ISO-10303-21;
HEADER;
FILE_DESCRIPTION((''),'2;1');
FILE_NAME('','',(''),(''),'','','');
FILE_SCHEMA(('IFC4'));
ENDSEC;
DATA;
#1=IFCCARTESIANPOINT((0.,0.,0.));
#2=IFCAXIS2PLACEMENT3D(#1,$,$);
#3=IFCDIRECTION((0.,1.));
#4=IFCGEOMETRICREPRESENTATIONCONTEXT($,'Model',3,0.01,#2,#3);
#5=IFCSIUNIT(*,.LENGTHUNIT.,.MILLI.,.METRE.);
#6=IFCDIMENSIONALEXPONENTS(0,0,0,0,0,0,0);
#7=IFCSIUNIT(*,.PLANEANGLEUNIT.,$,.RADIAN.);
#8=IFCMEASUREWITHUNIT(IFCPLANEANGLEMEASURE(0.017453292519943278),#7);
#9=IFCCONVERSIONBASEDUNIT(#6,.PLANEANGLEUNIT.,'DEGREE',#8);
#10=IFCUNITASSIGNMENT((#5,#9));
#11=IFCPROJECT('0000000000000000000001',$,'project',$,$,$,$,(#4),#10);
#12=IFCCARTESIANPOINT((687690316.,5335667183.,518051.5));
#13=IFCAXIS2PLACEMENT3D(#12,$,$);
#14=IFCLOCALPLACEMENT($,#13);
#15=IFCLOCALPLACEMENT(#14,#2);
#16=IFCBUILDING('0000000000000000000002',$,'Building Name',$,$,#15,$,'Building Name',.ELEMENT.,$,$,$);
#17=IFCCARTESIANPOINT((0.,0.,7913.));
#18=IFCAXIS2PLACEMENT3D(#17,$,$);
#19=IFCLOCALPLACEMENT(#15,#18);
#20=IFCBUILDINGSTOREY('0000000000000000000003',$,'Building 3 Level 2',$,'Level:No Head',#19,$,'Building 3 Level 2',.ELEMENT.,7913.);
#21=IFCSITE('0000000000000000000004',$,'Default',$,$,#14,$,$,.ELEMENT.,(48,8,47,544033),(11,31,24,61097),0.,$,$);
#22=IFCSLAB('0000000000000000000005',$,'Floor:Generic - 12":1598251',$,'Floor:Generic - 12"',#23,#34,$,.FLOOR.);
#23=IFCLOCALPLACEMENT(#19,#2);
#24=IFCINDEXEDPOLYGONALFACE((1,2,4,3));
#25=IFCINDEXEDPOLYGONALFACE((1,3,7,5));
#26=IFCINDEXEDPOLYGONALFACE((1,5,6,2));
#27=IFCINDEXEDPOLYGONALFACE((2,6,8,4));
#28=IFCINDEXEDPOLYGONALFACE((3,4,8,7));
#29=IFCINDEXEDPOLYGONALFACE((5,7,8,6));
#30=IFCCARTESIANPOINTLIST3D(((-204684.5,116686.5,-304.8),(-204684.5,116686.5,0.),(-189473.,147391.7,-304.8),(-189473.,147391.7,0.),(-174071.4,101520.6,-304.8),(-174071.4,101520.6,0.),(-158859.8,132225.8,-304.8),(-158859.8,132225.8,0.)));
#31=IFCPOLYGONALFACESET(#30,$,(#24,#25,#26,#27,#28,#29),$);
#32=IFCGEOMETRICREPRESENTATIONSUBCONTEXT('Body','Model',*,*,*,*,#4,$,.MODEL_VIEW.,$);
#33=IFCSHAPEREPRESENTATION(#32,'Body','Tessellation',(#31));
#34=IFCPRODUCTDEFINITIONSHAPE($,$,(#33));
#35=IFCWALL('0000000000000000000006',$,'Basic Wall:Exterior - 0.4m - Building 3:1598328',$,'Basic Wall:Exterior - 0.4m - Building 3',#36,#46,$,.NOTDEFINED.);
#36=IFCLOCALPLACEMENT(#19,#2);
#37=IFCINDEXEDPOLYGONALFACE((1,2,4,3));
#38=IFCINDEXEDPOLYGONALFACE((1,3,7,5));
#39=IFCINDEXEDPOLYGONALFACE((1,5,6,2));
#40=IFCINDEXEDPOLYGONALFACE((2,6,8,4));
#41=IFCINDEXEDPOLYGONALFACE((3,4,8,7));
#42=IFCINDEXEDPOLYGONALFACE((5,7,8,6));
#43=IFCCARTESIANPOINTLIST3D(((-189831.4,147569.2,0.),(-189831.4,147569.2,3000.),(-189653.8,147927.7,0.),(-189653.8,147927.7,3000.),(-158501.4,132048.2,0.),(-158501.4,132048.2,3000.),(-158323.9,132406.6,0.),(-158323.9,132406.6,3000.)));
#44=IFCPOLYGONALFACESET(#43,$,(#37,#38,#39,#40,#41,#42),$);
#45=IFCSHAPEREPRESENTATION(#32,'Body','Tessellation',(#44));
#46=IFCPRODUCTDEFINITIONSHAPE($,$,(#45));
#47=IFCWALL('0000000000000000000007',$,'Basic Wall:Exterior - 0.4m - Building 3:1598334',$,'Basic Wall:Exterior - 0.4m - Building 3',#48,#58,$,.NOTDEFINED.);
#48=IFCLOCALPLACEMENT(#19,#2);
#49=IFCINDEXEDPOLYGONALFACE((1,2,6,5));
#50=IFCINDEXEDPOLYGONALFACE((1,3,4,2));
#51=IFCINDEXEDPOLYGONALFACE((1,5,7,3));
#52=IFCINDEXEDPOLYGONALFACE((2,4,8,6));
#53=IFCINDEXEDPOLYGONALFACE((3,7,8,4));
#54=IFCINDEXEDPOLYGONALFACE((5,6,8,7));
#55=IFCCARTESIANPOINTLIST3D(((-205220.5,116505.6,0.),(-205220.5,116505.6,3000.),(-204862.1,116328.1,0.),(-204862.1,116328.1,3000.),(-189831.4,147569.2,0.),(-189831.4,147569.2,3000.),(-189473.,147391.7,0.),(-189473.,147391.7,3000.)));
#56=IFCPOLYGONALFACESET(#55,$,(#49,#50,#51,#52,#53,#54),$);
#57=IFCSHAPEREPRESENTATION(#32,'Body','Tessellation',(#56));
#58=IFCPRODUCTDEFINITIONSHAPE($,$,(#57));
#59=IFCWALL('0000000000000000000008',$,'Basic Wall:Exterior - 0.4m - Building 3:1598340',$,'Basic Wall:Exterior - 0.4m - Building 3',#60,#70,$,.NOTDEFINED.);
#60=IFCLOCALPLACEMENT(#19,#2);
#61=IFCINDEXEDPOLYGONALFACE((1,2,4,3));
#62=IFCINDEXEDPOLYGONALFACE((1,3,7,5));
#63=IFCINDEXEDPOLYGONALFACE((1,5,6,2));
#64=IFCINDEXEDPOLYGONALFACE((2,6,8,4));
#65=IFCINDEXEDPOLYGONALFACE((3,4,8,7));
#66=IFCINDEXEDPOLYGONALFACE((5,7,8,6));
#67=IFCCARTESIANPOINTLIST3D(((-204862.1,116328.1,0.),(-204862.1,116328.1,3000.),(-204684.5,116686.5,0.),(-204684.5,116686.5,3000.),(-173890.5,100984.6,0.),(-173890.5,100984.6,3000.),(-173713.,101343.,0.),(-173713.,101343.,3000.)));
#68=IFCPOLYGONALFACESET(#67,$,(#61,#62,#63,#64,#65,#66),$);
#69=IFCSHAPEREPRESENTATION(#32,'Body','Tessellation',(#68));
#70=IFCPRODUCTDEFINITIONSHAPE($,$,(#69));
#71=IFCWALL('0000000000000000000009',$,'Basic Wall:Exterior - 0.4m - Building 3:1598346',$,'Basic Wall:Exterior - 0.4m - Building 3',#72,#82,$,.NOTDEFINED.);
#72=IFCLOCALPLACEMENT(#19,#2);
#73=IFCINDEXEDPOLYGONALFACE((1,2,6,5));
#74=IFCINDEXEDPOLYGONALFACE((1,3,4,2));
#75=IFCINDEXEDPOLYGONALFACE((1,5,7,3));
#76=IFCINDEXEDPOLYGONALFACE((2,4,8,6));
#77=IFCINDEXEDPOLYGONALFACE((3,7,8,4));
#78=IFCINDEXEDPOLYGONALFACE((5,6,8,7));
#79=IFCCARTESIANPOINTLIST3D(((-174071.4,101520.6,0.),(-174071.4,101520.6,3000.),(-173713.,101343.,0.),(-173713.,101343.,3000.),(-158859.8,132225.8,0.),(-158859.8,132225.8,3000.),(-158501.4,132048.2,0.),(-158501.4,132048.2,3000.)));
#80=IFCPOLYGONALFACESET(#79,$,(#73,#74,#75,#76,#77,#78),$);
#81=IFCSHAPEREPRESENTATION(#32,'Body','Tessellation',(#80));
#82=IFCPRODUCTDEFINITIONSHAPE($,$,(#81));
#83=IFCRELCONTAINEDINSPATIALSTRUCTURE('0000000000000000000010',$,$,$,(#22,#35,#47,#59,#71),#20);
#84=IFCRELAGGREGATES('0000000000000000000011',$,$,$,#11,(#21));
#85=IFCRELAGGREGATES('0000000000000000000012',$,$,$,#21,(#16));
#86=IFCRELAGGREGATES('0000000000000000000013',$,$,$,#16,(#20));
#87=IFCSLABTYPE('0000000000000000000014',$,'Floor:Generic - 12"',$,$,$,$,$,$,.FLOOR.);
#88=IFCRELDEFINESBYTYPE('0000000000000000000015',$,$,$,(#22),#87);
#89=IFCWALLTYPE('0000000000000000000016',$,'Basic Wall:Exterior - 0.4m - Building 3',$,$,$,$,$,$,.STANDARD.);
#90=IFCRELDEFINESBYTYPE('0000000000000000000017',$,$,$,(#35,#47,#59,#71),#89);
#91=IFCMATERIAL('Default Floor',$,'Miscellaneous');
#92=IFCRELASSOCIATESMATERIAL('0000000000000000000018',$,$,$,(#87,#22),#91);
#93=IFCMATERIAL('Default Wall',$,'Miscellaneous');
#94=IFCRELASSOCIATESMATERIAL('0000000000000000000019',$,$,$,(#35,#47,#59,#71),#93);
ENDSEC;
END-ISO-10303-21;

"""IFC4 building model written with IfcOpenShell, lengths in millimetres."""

from ifc_helpers import new_model, entity, si_unit, converted_unit, direction, frame, origin, place, context, subcontext, project, spatial, indexed_curve, outline, extrude, material, type_object, element, save


model = new_model("IFC4")

# Units and contexts
model_context = context("Model", 3, precision=0.01, world=origin(), true_north=direction((0.0, 1.0)))
body_context = subcontext(model_context, "Body", "Model", "MODEL_VIEW")
ifc_project = project(units=[si_unit("LENGTHUNIT", "METRE", prefix="MILLI"), converted_unit("PLANEANGLEUNIT", "DEGREE", entity("IfcPlaneAngleMeasure", 0.017453292519943278), si_unit("PLANEANGLEUNIT", "RADIAN"), dimensions=[0, 0, 0, 0, 0, 0, 0])], contexts=[model_context])

# Site, building, storey
site_placement = place(None, frame((687690316.0, 5335667183.0, 518051.5)))
site = spatial("IfcSite", under=ifc_project, at=site_placement, Name="Default", CompositionType="ELEMENT", RefLatitude=(48, 8, 47, 544033), RefLongitude=(11, 31, 24, 61097), RefElevation=0.0)
building_placement = place(site_placement, origin())
building = spatial("IfcBuilding", under=site, at=building_placement, Name="Building Name", LongName="Building Name", CompositionType="ELEMENT")
storey_placement = place(building_placement, frame((0.0, 0.0, 7913.0)))
storey = spatial("IfcBuildingStorey", under=building, at=storey_placement, Name="Building 3 Level 2", ObjectType="Level:No Head", LongName="Building 3 Level 2", CompositionType="ELEMENT", Elevation=7913.0)

# Slab
ifc_material_1 = material(Name="Default Floor", Category="Miscellaneous")
slab_type = type_object("IfcSlabType", Name="Floor:Generic - 12\"", PredefinedType="FLOOR", material=ifc_material_1)
slab_placement = place(storey_placement, origin())
element("IfcSlab", 1, at=slab_placement, inside=storey, type_object=slab_type, material=ifc_material_1, Name="Floor:Generic - 12\":1598251", ObjectType="Floor:Generic - 12\"", PredefinedType="FLOOR", context=body_context, shape_type="SweptSolid", body=[
    extrude(outline(indexed_curve([(-17081.9, -17133.3), (17081.9, -17133.3), (17081.9, 17133.3), (-17081.9, 17133.3), (-17081.9, -17133.3)], self_intersect=False)), frame((-181772.2, 124456.1, 0.0), z_axis=(0.0, 0.0, -1.0), x_axis=(0.896068, -0.443917, 0.0)), (0.0, 0.0, 1.0), 304.8),
])

# Walls
ifc_material_2 = material(Name="Default Wall", Category="Miscellaneous")
wall_type = type_object("IfcWallType", Name="Basic Wall:Exterior - 0.4m - Building 3", PredefinedType="STANDARD")
wall_1_placement = place(storey_placement, frame((-158412.6, 132227.4, 0.0), z_axis=(0.0, 0.0, 1.0), x_axis=(-0.896068, 0.443917, 0.0)))
element("IfcWall", 2, at=wall_1_placement, inside=storey, type_object=wall_type, material=ifc_material_2, Name="Basic Wall:Exterior - 0.4m - Building 3:1598328", ObjectType="Basic Wall:Exterior - 0.4m - Building 3", PredefinedType="NOTDEFINED", context=body_context, shape_type="SweptSolid", body=[
    extrude(outline(indexed_curve([(34963.8, 200.0), (0.0, 200.0), (0.0, -200.0), (34963.8, -200.0), (34963.8, 200.0)], self_intersect=False)), origin(), (0.0, 0.0, 1.0), 3000.0),
])
wall_2_placement = place(storey_placement, frame((-189652.2, 147480.5, 0.0), z_axis=(0.0, 0.0, 1.0), x_axis=(-0.443917, -0.896068, 0.0)))
element("IfcWall", 3, at=wall_2_placement, inside=storey, type_object=wall_type, material=ifc_material_2, Name="Basic Wall:Exterior - 0.4m - Building 3:1598334", ObjectType="Basic Wall:Exterior - 0.4m - Building 3", PredefinedType="NOTDEFINED", context=body_context, shape_type="SweptSolid", body=[
    extrude(outline(indexed_curve([(34666.6, 200.0), (0.0, 200.0), (0.0, -200.0), (34666.6, -200.0), (34666.6, 200.0)], self_intersect=False)), origin(), (0.0, 0.0, 1.0), 3000.0),
])
wall_3_placement = place(storey_placement, frame((-204773.3, 116507.3, 0.0), z_axis=(0.0, 0.0, 1.0), x_axis=(0.896068, -0.443917, 0.0)))
element("IfcWall", 4, at=wall_3_placement, inside=storey, type_object=wall_type, material=ifc_material_2, Name="Basic Wall:Exterior - 0.4m - Building 3:1598340", ObjectType="Basic Wall:Exterior - 0.4m - Building 3", PredefinedType="NOTDEFINED", context=body_context, shape_type="SweptSolid", body=[
    extrude(outline(indexed_curve([(34563.8, 200.0), (0.0, 200.0), (0.0, -200.0), (34563.8, -200.0), (34563.8, 200.0)], self_intersect=False)), origin(), (0.0, 0.0, 1.0), 3000.0),
])
wall_4_placement = place(storey_placement, frame((-173892.2, 101431.8, 0.0), z_axis=(0.0, 0.0, 1.0), x_axis=(0.443917, 0.896068, 0.0)))
element("IfcWall", 5, at=wall_4_placement, inside=storey, type_object=wall_type, material=ifc_material_2, Name="Basic Wall:Exterior - 0.4m - Building 3:1598346", ObjectType="Basic Wall:Exterior - 0.4m - Building 3", PredefinedType="NOTDEFINED", context=body_context, shape_type="SweptSolid", body=[
    extrude(outline(indexed_curve([(34266.6, 200.0), (0.0, 200.0), (0.0, -200.0), (34266.6, -200.0), (34266.6, 200.0)], self_intersect=False)), origin(), (0.0, 0.0, 1.0), 3000.0),
])

save(model, "model.ifc")
